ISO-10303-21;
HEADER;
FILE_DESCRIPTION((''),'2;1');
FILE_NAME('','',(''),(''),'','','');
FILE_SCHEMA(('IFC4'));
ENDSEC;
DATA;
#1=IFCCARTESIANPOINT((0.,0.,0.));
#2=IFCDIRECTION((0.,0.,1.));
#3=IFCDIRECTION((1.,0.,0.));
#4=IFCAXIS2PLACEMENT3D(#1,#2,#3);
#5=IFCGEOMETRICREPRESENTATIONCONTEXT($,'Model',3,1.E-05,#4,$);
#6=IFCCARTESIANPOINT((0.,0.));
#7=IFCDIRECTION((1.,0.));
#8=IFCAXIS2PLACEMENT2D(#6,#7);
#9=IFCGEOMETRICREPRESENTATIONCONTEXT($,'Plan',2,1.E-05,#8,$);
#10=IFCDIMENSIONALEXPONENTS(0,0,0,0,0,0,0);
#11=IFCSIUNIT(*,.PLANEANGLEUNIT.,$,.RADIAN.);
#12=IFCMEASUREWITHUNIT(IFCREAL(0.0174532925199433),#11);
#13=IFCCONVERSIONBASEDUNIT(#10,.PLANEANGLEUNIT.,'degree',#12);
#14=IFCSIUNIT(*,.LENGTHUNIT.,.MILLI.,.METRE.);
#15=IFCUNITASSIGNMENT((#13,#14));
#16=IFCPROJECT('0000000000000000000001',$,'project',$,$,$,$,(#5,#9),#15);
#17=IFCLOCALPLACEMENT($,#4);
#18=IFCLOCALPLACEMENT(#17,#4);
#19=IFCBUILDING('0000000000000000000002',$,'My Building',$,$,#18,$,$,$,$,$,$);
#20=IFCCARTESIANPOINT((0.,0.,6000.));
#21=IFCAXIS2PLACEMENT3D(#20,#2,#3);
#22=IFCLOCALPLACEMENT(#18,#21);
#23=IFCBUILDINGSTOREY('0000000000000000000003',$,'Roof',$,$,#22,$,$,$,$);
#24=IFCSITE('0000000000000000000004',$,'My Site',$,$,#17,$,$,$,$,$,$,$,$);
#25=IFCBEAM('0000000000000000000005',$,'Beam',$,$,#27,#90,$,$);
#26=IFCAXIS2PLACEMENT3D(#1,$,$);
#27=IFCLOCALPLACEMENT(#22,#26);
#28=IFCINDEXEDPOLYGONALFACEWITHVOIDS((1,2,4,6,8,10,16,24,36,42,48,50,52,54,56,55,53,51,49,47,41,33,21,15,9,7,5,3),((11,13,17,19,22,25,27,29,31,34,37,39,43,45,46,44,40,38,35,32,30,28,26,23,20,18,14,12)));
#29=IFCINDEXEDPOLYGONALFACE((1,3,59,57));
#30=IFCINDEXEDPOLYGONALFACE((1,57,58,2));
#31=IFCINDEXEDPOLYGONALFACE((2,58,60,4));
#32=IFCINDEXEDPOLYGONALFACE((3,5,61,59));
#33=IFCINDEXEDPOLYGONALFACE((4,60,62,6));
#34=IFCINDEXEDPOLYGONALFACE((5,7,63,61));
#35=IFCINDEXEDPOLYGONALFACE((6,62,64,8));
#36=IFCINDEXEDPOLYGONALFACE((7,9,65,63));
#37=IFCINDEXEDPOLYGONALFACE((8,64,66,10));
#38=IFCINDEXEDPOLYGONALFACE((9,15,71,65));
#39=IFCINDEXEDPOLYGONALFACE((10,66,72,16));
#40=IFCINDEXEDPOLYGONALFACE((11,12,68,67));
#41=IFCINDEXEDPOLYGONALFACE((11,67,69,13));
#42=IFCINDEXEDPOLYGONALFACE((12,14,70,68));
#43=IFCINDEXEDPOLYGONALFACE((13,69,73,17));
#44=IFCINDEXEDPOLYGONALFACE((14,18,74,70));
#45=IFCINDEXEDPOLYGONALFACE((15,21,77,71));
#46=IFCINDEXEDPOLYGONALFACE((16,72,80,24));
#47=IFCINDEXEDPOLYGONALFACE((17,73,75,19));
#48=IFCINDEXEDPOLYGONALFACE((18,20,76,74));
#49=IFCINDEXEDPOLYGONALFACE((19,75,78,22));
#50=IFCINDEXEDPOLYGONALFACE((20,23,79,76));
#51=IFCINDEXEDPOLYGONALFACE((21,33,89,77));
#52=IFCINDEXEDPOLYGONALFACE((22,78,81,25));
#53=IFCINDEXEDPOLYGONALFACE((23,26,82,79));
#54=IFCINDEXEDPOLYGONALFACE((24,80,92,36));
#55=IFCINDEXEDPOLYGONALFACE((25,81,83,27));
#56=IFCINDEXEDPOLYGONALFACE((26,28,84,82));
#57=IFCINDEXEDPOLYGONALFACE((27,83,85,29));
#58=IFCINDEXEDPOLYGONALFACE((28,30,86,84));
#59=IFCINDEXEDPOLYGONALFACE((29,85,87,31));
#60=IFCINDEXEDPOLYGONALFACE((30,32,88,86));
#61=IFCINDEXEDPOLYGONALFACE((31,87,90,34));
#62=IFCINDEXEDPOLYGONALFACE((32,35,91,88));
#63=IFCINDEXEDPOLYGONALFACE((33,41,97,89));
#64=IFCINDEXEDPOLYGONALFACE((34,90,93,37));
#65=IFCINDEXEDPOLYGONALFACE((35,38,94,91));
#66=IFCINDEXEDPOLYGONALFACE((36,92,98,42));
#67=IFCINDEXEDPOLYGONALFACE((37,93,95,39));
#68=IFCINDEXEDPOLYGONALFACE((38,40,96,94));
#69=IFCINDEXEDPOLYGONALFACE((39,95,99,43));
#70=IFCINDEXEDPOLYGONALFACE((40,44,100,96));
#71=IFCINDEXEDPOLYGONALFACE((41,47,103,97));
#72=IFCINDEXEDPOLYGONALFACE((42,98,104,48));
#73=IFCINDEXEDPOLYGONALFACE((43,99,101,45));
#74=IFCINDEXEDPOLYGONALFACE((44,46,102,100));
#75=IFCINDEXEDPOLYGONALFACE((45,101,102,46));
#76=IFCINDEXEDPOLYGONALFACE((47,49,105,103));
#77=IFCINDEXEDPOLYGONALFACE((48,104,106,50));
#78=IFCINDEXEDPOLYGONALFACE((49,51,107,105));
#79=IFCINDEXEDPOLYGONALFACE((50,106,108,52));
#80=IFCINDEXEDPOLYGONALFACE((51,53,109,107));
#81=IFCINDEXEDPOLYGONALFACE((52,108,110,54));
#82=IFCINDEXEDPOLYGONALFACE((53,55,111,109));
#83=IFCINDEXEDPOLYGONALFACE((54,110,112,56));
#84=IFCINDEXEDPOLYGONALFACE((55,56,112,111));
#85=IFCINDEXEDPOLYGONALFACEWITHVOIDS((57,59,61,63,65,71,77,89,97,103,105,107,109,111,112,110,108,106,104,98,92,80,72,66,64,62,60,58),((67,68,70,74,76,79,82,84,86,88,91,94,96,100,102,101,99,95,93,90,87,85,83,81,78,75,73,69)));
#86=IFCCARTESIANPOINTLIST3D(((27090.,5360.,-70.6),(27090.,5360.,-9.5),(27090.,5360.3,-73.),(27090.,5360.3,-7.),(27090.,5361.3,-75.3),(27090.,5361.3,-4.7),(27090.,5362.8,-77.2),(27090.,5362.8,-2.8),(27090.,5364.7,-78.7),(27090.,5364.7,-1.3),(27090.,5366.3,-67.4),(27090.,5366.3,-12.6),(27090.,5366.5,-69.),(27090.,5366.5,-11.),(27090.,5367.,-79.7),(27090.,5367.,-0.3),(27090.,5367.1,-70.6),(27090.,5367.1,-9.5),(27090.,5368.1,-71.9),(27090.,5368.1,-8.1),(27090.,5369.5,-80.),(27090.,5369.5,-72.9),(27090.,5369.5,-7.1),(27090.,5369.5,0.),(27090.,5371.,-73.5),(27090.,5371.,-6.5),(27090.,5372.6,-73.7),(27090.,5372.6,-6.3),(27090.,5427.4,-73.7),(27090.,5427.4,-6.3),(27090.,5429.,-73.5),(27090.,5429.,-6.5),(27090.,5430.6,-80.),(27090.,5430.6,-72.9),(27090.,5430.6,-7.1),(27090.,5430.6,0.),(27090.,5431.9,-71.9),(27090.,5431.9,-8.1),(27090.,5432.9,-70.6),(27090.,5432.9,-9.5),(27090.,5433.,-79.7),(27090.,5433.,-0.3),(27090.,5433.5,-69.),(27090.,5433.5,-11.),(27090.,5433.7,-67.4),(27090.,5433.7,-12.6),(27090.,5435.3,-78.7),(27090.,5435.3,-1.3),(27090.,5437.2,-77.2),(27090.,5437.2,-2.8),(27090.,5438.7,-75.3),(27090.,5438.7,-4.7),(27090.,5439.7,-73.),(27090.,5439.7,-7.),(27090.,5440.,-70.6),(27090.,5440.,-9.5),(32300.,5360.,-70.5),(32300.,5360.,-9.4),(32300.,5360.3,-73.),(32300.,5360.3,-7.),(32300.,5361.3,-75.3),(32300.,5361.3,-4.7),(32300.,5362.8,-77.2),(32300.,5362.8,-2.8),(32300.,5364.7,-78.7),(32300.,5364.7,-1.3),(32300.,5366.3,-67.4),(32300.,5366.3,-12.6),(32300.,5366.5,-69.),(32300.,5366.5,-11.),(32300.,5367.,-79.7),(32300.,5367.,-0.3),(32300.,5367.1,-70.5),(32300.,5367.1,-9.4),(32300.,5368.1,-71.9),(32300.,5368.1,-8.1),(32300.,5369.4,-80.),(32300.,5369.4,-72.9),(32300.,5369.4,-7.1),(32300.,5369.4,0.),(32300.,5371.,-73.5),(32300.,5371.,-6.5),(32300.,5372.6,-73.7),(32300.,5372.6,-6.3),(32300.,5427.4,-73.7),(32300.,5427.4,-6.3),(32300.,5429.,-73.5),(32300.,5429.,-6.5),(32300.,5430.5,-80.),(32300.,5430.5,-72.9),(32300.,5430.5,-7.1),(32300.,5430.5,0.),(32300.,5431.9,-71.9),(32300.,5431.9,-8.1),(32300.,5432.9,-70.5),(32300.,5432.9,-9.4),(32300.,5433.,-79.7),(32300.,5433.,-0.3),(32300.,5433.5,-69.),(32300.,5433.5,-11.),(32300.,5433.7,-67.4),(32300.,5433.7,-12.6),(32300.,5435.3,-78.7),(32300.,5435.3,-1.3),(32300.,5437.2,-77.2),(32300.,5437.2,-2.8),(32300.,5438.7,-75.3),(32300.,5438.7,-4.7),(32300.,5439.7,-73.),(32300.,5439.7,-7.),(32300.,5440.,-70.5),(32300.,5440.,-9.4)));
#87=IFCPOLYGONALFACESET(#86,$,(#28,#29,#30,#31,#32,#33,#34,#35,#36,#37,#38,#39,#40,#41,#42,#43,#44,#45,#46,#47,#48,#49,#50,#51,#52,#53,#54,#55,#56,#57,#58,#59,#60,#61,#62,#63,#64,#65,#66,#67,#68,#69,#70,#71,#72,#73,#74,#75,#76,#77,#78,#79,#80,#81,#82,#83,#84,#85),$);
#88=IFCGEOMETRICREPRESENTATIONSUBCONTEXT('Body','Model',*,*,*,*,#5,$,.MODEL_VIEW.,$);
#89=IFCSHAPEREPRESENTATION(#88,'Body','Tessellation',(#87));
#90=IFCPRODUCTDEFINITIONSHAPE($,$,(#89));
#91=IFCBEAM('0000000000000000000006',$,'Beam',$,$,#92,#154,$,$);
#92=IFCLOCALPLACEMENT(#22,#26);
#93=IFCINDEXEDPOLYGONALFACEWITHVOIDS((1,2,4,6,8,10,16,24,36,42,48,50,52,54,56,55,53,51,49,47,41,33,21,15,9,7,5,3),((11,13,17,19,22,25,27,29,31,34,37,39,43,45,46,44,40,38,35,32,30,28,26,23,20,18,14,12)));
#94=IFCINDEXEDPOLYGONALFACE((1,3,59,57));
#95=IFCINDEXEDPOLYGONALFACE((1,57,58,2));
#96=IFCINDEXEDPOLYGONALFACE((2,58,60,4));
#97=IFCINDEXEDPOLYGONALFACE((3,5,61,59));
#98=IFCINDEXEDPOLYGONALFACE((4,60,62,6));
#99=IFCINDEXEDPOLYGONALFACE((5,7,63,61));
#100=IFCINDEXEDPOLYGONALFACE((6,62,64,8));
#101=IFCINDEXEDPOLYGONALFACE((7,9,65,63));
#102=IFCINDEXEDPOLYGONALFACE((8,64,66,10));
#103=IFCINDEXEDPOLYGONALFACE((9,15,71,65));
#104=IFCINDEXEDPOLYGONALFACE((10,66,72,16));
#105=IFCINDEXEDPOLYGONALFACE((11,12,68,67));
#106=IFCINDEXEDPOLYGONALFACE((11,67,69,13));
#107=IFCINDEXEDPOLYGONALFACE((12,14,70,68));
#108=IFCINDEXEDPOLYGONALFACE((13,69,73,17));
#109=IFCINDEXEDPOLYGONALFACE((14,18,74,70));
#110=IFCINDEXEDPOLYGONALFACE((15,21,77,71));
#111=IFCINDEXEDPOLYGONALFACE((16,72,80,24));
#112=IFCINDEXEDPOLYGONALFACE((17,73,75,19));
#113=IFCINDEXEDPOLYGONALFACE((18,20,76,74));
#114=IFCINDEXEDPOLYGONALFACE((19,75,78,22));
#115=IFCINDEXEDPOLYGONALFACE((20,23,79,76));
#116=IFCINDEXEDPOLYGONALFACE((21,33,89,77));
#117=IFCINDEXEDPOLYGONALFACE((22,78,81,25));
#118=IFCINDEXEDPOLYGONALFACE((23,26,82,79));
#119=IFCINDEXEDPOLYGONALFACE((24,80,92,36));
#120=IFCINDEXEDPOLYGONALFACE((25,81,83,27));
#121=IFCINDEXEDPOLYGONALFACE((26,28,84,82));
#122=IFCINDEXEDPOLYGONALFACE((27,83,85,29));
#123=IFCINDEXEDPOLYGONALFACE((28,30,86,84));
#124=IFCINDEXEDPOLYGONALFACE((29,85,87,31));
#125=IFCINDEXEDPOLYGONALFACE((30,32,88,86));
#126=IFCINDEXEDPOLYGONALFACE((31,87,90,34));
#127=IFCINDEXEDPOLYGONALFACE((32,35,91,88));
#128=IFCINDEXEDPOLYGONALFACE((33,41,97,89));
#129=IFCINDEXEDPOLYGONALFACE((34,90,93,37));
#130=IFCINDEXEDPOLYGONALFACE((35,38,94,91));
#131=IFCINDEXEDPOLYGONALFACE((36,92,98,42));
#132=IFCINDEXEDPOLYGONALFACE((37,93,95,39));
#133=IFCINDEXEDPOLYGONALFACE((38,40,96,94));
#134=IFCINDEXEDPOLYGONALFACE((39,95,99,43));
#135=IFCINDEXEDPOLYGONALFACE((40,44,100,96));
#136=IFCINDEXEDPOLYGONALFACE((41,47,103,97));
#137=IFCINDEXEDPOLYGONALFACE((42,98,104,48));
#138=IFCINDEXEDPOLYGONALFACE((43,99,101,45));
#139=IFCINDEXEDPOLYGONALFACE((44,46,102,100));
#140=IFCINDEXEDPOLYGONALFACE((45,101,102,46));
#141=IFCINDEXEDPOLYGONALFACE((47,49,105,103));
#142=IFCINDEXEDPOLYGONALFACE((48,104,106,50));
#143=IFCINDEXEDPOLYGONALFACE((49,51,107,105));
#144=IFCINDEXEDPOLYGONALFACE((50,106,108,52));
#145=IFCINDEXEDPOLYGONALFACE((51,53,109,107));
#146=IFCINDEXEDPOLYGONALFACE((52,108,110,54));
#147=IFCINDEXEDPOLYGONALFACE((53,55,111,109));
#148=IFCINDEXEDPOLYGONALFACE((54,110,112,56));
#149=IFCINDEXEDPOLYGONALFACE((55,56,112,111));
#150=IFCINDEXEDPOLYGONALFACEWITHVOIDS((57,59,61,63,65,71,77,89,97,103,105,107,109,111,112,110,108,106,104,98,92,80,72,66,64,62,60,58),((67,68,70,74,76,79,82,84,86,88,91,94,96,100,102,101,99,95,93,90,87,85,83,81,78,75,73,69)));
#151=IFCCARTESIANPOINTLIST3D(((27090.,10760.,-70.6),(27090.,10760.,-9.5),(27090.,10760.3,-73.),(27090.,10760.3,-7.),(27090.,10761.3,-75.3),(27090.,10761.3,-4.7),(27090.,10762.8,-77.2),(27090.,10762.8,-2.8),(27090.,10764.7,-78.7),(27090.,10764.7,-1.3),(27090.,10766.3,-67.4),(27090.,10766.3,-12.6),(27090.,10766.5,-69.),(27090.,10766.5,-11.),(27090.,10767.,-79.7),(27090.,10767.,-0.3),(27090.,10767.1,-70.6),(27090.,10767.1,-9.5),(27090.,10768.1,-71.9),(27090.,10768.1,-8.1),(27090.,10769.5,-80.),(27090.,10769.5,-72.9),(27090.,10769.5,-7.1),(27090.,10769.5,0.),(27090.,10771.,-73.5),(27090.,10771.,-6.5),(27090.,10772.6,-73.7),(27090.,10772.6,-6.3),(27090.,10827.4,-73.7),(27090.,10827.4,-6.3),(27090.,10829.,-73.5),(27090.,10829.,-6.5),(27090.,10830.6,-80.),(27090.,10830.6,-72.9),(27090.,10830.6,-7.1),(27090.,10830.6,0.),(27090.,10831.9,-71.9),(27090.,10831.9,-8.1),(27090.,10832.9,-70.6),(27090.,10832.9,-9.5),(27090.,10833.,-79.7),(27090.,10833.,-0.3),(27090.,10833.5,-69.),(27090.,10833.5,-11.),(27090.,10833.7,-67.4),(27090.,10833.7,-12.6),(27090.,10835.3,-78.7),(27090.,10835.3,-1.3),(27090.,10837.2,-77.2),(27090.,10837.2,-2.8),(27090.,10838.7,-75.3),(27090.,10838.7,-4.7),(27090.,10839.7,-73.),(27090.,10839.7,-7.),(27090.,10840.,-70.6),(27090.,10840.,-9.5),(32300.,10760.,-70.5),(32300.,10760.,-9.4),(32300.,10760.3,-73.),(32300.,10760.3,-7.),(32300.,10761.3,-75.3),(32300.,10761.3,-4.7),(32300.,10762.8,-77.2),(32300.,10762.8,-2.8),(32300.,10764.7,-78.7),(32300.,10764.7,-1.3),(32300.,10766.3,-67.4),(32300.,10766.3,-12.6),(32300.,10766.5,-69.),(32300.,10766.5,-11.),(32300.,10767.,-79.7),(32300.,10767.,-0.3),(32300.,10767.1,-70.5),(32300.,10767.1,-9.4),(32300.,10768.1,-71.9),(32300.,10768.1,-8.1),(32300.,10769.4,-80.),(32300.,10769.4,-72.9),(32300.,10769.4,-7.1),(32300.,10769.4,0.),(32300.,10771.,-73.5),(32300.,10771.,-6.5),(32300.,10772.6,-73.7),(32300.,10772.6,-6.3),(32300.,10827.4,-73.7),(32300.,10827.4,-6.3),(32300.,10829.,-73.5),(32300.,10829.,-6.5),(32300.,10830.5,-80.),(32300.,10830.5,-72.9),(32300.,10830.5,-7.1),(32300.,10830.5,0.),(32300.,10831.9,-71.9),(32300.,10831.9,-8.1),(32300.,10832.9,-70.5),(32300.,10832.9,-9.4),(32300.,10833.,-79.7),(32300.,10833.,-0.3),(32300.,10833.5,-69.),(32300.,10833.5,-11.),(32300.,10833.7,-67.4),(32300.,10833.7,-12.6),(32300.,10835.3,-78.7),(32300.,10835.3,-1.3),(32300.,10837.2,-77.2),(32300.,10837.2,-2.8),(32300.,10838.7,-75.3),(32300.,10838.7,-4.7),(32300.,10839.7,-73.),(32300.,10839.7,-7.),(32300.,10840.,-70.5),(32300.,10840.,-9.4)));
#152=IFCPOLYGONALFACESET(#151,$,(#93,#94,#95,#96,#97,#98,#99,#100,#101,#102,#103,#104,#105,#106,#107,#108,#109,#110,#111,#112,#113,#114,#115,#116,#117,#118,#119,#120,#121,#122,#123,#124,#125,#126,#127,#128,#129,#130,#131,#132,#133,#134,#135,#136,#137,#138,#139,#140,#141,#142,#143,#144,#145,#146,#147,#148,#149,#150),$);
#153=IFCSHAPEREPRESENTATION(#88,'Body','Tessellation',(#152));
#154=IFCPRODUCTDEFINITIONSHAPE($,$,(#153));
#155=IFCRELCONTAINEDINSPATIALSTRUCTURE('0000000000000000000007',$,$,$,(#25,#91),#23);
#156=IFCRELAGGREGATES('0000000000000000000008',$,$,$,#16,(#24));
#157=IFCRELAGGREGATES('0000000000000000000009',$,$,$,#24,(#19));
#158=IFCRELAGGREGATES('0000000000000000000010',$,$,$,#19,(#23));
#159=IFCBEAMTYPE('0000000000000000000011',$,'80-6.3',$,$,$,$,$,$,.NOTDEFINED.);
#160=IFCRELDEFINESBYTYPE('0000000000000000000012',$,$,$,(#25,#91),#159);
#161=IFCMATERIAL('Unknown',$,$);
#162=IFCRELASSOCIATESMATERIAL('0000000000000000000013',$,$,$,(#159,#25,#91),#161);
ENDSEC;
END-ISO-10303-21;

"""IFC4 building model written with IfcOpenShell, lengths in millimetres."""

from ifc_helpers import new_model, entity, si_unit, converted_unit, frame, origin_with_axes, origin_2d_with_axis, place, context, subcontext, project, spatial, hollow_rectangle, extrude, material, material_profile, profile_set, profile_usage, type_object, element, save


model = new_model("IFC4")

# Units and contexts
model_context = context("Model", 3, precision=1e-05, world=origin_with_axes())
plan_context = context("Plan", 2, precision=1e-05, world=origin_2d_with_axis())
body_context = subcontext(model_context, "Body", "Model", "MODEL_VIEW")
ifc_project = project(units=[converted_unit("PLANEANGLEUNIT", "degree", entity("IfcReal", 0.0174532925199433), si_unit("PLANEANGLEUNIT", "RADIAN"), dimensions=[0, 0, 0, 0, 0, 0, 0]), si_unit("LENGTHUNIT", "METRE", prefix="MILLI")], contexts=[model_context, plan_context])

# Site, building, storey
site_placement = place(None, origin_with_axes())
site = spatial("IfcSite", under=ifc_project, at=site_placement, Name="My Site")
building_placement = place(site_placement, origin_with_axes())
building = spatial("IfcBuilding", under=site, at=building_placement, Name="My Building")
storey_placement = place(building_placement, frame((0.0, 0.0, 6000.0), z_axis=(0.0, 0.0, 1.0), x_axis=(1.0, 0.0, 0.0)))
storey = spatial("IfcBuildingStorey", under=building, at=storey_placement, Name="Roof")

# Beams
ifc_material = material(Name="Unknown")
ifc_material_profile_1 = material_profile(ifc_material, hollow_rectangle(XDim=80.0, YDim=80.0, WallThickness=6.3, InnerFilletRadius=6.3, OuterFilletRadius=9.4))
ifc_profile_set_1 = profile_set([ifc_material_profile_1])
ifc_profile_usage_1 = profile_usage(ifc_profile_set_1, cardinal=8)
beam_type_1 = type_object("IfcBeamType", Name="80-6.3", PredefinedType="NOTDEFINED", material=ifc_profile_set_1)
beam_1_placement = place(storey_placement, frame((27090.0, 5400.0, 0.0), z_axis=(1.0, 0.0, 0.0), x_axis=(0.0, 1.0, 0.0)))
element("IfcBeam", 1, at=beam_1_placement, inside=storey, type_object=beam_type_1, material=ifc_profile_usage_1, Name="Beam", context=body_context, shape_type="SweptSolid", body=[
    extrude(hollow_rectangle(XDim=80.0, YDim=80.0, WallThickness=6.3, InnerFilletRadius=6.3, OuterFilletRadius=9.4), frame((0.0, -40.0, 0.0), z_axis=(0.0, 0.0, 1.0), x_axis=(1.0, 0.0, 0.0)), (0.0, 0.0, 1.0), 5210.0),
])
ifc_profile_usage_2 = profile_usage(ifc_profile_set_1, cardinal=8)
beam_2_placement = place(storey_placement, frame((27090.0, 10800.0, 0.0), z_axis=(1.0, 0.0, 0.0), x_axis=(0.0, 1.0, 0.0)))
element("IfcBeam", 2, at=beam_2_placement, inside=storey, type_object=beam_type_1, material=ifc_profile_usage_2, Name="Beam", context=body_context, shape_type="SweptSolid", body=[
    extrude(hollow_rectangle(XDim=80.0, YDim=80.0, WallThickness=6.3, InnerFilletRadius=6.3, OuterFilletRadius=9.4), frame((0.0, -40.0, 0.0), z_axis=(0.0, 0.0, 1.0), x_axis=(1.0, 0.0, 0.0)), (0.0, 0.0, 1.0), 5210.0),
])

save(model, "model.ifc")
